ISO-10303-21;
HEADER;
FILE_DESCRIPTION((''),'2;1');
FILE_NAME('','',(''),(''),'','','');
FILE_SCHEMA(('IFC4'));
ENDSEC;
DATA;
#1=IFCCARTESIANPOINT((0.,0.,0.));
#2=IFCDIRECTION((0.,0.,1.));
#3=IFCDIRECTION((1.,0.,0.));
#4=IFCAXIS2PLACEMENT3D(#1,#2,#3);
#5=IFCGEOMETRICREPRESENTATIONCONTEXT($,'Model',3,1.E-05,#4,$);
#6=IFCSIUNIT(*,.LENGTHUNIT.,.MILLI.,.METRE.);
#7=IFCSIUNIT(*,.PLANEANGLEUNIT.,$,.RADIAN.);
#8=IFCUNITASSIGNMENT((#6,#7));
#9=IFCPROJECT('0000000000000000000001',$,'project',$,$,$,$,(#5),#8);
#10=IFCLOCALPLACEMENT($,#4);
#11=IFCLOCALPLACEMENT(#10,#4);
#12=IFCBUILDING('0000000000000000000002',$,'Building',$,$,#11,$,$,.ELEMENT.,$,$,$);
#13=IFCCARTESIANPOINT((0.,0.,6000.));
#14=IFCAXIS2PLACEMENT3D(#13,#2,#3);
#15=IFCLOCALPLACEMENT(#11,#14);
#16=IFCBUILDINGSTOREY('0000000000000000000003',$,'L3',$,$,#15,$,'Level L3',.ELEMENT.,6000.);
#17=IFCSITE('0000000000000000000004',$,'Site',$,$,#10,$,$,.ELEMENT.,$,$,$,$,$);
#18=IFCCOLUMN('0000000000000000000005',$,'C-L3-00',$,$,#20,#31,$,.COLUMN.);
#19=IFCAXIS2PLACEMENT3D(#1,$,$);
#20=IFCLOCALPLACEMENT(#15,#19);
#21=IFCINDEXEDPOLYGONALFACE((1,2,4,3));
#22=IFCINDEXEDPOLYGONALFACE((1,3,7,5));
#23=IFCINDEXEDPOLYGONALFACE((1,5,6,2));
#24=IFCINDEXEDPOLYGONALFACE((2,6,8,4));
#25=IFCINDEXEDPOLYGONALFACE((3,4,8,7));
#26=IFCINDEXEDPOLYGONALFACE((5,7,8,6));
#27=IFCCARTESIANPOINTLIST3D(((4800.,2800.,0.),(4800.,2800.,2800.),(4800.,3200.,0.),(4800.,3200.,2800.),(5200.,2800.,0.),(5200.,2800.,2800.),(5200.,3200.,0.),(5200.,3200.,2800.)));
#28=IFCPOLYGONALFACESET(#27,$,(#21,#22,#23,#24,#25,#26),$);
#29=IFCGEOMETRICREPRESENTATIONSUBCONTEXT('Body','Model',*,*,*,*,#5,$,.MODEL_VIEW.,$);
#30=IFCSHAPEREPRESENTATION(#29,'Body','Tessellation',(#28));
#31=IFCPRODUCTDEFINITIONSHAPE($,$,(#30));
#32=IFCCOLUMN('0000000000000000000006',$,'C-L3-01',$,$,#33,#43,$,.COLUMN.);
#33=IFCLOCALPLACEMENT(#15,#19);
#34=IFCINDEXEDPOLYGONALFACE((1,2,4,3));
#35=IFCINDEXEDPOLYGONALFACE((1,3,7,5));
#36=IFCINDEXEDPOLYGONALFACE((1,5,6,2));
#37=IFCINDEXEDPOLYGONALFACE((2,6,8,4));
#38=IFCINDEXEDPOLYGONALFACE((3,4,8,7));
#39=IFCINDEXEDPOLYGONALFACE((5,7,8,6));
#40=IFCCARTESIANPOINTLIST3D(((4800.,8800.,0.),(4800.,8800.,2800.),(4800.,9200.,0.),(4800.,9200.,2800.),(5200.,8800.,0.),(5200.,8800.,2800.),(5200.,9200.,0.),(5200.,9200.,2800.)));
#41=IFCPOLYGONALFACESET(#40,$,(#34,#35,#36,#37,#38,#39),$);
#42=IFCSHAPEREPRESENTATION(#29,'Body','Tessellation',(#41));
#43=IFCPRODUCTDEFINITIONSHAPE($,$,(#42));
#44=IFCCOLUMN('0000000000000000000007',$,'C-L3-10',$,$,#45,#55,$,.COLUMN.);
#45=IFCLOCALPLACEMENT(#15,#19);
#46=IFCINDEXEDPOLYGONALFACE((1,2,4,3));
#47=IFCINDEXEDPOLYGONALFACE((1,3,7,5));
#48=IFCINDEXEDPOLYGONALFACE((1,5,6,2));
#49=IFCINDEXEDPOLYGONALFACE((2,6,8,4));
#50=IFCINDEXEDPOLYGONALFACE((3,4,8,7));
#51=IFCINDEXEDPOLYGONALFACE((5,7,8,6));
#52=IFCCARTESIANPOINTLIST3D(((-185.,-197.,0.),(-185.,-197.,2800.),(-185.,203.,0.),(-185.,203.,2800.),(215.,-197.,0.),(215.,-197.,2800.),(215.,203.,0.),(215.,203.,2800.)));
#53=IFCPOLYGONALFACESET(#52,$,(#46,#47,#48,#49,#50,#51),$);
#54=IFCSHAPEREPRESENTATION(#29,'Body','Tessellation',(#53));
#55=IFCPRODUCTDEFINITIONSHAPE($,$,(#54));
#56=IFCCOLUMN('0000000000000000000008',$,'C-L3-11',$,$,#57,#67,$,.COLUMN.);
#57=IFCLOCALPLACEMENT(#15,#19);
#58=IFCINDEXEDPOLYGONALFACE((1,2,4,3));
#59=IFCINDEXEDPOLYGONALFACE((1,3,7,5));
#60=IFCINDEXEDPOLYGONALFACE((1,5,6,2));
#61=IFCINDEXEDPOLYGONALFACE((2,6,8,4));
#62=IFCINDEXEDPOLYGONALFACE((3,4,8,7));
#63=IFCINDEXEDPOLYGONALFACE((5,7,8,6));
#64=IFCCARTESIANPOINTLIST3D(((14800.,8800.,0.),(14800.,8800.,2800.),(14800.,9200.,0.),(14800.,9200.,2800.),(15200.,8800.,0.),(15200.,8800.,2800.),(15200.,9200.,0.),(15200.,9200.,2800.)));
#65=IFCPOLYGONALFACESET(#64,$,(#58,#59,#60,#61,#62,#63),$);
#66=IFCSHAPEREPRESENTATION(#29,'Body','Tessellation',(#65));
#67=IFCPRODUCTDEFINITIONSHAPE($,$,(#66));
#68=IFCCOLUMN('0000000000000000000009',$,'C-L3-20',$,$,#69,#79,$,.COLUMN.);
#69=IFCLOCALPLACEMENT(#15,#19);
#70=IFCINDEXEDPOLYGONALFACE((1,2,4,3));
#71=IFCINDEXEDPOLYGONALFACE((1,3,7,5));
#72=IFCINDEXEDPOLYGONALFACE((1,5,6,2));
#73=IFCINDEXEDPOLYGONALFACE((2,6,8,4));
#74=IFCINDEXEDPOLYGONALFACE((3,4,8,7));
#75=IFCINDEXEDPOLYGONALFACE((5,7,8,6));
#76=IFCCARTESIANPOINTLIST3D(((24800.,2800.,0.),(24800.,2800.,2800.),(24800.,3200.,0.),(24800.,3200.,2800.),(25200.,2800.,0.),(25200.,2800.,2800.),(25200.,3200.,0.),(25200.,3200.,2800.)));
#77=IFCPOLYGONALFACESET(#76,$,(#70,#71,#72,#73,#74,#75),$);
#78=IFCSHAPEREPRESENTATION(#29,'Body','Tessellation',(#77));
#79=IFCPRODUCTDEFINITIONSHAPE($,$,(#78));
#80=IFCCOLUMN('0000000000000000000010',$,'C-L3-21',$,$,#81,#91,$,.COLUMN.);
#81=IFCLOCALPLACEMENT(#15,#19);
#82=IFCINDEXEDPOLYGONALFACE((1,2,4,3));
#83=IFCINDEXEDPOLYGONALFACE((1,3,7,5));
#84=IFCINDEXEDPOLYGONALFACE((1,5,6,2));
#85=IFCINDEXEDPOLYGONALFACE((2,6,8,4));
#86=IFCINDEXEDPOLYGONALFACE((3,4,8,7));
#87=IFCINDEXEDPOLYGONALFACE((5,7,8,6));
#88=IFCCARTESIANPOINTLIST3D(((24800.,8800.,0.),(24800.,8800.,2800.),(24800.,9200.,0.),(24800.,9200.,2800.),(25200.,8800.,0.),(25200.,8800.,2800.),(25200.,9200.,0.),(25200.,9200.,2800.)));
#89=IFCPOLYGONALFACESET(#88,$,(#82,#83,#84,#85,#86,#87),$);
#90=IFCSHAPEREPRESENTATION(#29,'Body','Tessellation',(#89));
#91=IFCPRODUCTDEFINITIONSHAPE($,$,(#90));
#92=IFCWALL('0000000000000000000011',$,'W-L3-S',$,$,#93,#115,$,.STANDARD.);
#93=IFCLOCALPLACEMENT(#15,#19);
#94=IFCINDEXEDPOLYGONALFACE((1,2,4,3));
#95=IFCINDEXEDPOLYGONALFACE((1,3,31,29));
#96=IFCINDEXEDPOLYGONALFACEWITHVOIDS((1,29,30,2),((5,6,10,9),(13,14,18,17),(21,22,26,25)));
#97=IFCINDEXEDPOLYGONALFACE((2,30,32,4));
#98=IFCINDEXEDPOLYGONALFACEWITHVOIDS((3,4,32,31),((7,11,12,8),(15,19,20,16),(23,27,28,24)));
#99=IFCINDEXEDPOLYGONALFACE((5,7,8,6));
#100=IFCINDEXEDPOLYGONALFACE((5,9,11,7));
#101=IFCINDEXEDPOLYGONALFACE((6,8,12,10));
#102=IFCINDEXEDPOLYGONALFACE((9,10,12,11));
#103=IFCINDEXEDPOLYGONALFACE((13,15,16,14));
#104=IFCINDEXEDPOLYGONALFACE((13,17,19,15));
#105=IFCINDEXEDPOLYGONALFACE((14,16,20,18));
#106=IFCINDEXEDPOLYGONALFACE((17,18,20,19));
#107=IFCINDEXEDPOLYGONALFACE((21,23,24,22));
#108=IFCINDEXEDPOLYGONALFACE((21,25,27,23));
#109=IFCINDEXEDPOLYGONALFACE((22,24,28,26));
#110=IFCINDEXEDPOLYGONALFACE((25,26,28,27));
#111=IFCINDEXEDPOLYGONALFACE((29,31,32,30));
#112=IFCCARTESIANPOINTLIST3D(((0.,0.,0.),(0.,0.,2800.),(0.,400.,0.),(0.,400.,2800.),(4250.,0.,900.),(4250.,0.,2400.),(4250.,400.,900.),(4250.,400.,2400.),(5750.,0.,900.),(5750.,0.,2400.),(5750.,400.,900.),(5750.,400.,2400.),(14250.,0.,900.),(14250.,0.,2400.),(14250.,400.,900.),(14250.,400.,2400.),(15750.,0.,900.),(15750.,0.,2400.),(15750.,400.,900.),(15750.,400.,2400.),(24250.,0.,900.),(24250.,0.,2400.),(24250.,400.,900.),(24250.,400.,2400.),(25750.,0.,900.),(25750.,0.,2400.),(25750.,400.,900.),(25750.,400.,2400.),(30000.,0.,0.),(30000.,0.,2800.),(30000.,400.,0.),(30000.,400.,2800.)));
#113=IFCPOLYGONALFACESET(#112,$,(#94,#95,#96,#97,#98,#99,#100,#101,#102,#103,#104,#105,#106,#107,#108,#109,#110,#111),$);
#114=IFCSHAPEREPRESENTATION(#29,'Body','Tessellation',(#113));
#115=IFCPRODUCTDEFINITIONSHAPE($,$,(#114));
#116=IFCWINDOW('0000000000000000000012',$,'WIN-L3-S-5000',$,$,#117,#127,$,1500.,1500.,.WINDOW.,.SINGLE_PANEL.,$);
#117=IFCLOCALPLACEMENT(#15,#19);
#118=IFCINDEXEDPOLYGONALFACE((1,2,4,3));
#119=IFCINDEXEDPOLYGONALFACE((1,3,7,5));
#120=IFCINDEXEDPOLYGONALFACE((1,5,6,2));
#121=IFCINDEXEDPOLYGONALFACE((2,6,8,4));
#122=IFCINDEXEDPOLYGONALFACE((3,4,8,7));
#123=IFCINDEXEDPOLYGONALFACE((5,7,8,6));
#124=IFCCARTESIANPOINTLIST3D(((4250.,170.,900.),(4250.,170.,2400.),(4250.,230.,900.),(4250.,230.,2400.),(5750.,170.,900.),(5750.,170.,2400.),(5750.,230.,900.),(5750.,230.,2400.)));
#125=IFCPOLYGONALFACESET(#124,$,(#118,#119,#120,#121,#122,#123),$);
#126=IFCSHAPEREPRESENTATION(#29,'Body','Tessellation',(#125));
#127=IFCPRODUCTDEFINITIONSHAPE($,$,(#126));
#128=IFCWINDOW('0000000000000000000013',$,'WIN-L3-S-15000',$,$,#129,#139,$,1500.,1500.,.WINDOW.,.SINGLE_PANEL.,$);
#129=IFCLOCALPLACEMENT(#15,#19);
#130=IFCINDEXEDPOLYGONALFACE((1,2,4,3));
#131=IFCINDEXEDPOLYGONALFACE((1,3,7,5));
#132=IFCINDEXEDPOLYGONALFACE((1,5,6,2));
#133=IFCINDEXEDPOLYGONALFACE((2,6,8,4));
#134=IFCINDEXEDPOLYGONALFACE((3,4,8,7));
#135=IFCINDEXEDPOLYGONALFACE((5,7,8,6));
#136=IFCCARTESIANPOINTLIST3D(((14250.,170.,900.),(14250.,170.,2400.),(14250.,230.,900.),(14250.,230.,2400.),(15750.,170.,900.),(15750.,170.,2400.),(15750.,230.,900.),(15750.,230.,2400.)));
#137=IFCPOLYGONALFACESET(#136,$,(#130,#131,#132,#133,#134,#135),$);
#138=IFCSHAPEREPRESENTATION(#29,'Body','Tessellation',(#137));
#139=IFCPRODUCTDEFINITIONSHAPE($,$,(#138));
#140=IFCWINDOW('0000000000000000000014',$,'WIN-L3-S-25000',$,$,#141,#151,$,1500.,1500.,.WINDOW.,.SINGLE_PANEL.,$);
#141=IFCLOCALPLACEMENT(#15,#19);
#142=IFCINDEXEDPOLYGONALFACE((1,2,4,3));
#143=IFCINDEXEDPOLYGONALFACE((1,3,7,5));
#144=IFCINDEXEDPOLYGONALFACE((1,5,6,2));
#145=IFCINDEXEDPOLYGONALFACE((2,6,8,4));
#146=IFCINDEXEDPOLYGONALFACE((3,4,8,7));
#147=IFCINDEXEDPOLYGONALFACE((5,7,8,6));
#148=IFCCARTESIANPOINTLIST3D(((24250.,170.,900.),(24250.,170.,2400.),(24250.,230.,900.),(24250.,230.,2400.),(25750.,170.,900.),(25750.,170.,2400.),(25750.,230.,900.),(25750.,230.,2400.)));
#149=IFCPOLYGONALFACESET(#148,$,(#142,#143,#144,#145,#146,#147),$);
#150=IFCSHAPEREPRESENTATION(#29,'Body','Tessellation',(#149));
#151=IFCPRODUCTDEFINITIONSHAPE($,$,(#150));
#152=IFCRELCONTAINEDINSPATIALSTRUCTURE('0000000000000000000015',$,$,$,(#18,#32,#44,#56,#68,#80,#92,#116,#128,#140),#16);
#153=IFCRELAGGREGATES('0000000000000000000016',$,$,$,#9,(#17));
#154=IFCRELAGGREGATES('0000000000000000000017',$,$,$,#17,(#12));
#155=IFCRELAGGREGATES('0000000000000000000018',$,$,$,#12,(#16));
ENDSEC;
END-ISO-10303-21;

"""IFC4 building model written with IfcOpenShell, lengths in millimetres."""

from ifc_helpers import new_model, si_unit, frame, origin_with_axes, origin_2d, place, context, subcontext, project, spatial, rectangle, extrude, element, fill, save


model = new_model("IFC4")

# Units and contexts
model_context = context("Model", 3, precision=1e-05, world=origin_with_axes())
body_context = subcontext(model_context, "Body", "Model", "MODEL_VIEW")
ifc_project = project(units=[si_unit("LENGTHUNIT", "METRE", prefix="MILLI"), si_unit("PLANEANGLEUNIT", "RADIAN")], contexts=[model_context])

# Site, building, storey
site_placement = place(None, origin_with_axes())
site = spatial("IfcSite", under=ifc_project, at=site_placement, Name="Site", CompositionType="ELEMENT")
building_placement = place(site_placement, origin_with_axes())
building = spatial("IfcBuilding", under=site, at=building_placement, Name="Building", CompositionType="ELEMENT")
storey_placement = place(building_placement, frame((0.0, 0.0, 6000.0), z_axis=(0.0, 0.0, 1.0), x_axis=(1.0, 0.0, 0.0)))
storey = spatial("IfcBuildingStorey", under=building, at=storey_placement, Name="L3", LongName="Level L3", CompositionType="ELEMENT", Elevation=6000.0)

# Columns
for number, where, z_axis, x_axis, name in (
    (1, (5000.0, 3000.0, 0.0), (0.0, 0.0, 1.0), (1.0, 0.0, 0.0), "C-L3-00"),
    (2, (5000.0, 9000.0, 0.0), (0.0, 0.0, 1.0), (1.0, 0.0, 0.0), "C-L3-01"),
    (3, (15.0, 3.0, 0.0), (0.0, 0.0, 1.0), (1.0, 0.0, 0.0), "C-L3-10"),
    (4, (15000.0, 9000.0, 0.0), (0.0, 0.0, 1.0), (1.0, 0.0, 0.0), "C-L3-11"),
    (5, (25000.0, 3000.0, 0.0), (0.0, 0.0, 1.0), (1.0, 0.0, 0.0), "C-L3-20"),
    (6, (25000.0, 9000.0, 0.0), (0.0, 0.0, 1.0), (1.0, 0.0, 0.0), "C-L3-21"),
):
    element("IfcColumn", number, at=place(storey_placement, frame(where, z_axis=z_axis, x_axis=x_axis)), inside=storey, Name=name, PredefinedType="COLUMN", context=body_context, shape_type="SweptSolid", body=[
        extrude(rectangle(XDim=400.0, YDim=400.0, at=origin_2d()), origin_with_axes(), (0.0, 0.0, 1.0), 2800.0),
    ])

# Wall, openings, windows
wall_1_placement = place(storey_placement, frame((15000.0, 200.0, 0.0), z_axis=(0.0, 0.0, 1.0), x_axis=(1.0, 0.0, 0.0)))
wall_1 = element("IfcWall", 7, at=wall_1_placement, inside=storey, Name="W-L3-S", PredefinedType="STANDARD", context=body_context, shape_type="SweptSolid", body=[
    extrude(rectangle(XDim=30000.0, YDim=400.0, at=origin_2d()), origin_with_axes(), (0.0, 0.0, 1.0), 2800.0),
])
opening_1_placement = place(wall_1_placement, frame((-10000.0, 0.0, 900.0), z_axis=(0.0, 0.0, 1.0), x_axis=(1.0, 0.0, 0.0)))
opening_1 = element("IfcOpeningElement", 8, at=opening_1_placement, cuts=wall_1, PredefinedType="OPENING", context=body_context, shape_type="SweptSolid", body=[
    extrude(rectangle(XDim=1500.0, YDim=500.0, at=origin_2d()), origin_with_axes(), (0.0, 0.0, 1.0), 1500.0),
])
opening_2_placement = place(wall_1_placement, frame((0.0, 0.0, 900.0), z_axis=(0.0, 0.0, 1.0), x_axis=(1.0, 0.0, 0.0)))
opening_2 = element("IfcOpeningElement", 9, at=opening_2_placement, cuts=wall_1, PredefinedType="OPENING", context=body_context, shape_type="SweptSolid", body=[
    extrude(rectangle(XDim=1500.0, YDim=500.0, at=origin_2d()), origin_with_axes(), (0.0, 0.0, 1.0), 1500.0),
])
opening_3_placement = place(wall_1_placement, frame((10000.0, 0.0, 900.0), z_axis=(0.0, 0.0, 1.0), x_axis=(1.0, 0.0, 0.0)))
opening_3 = element("IfcOpeningElement", 10, at=opening_3_placement, cuts=wall_1, PredefinedType="OPENING", context=body_context, shape_type="SweptSolid", body=[
    extrude(rectangle(XDim=1500.0, YDim=500.0, at=origin_2d()), origin_with_axes(), (0.0, 0.0, 1.0), 1500.0),
])
window_1_placement = place(wall_1_placement, frame((-10000.0, 0.0, 900.0), z_axis=(0.0, 0.0, 1.0), x_axis=(1.0, 0.0, 0.0)))
window_1 = element("IfcWindow", 11, at=window_1_placement, inside=storey, Name="WIN-L3-S-5000", OverallHeight=1500.0, OverallWidth=1500.0, PartitioningType="SINGLE_PANEL", PredefinedType="WINDOW", context=body_context, shape_type="SweptSolid", body=[
    extrude(rectangle(XDim=1500.0, YDim=60.0, at=origin_2d()), origin_with_axes(), (0.0, 0.0, 1.0), 1500.0),
])
fill(opening_1, window_1)
window_2_placement = place(wall_1_placement, frame((0.0, 0.0, 900.0), z_axis=(0.0, 0.0, 1.0), x_axis=(1.0, 0.0, 0.0)))
window_2 = element("IfcWindow", 12, at=window_2_placement, inside=storey, Name="WIN-L3-S-15000", OverallHeight=1500.0, OverallWidth=1500.0, PartitioningType="SINGLE_PANEL", PredefinedType="WINDOW", context=body_context, shape_type="SweptSolid", body=[
    extrude(rectangle(XDim=1500.0, YDim=60.0, at=origin_2d()), origin_with_axes(), (0.0, 0.0, 1.0), 1500.0),
])
fill(opening_2, window_2)
window_3_placement = place(wall_1_placement, frame((10000.0, 0.0, 900.0), z_axis=(0.0, 0.0, 1.0), x_axis=(1.0, 0.0, 0.0)))
window_3 = element("IfcWindow", 13, at=window_3_placement, inside=storey, Name="WIN-L3-S-25000", OverallHeight=1500.0, OverallWidth=1500.0, PartitioningType="SINGLE_PANEL", PredefinedType="WINDOW", context=body_context, shape_type="SweptSolid", body=[
    extrude(rectangle(XDim=1500.0, YDim=60.0, at=origin_2d()), origin_with_axes(), (0.0, 0.0, 1.0), 1500.0),
])
fill(opening_3, window_3)

save(model, "model.ifc")
